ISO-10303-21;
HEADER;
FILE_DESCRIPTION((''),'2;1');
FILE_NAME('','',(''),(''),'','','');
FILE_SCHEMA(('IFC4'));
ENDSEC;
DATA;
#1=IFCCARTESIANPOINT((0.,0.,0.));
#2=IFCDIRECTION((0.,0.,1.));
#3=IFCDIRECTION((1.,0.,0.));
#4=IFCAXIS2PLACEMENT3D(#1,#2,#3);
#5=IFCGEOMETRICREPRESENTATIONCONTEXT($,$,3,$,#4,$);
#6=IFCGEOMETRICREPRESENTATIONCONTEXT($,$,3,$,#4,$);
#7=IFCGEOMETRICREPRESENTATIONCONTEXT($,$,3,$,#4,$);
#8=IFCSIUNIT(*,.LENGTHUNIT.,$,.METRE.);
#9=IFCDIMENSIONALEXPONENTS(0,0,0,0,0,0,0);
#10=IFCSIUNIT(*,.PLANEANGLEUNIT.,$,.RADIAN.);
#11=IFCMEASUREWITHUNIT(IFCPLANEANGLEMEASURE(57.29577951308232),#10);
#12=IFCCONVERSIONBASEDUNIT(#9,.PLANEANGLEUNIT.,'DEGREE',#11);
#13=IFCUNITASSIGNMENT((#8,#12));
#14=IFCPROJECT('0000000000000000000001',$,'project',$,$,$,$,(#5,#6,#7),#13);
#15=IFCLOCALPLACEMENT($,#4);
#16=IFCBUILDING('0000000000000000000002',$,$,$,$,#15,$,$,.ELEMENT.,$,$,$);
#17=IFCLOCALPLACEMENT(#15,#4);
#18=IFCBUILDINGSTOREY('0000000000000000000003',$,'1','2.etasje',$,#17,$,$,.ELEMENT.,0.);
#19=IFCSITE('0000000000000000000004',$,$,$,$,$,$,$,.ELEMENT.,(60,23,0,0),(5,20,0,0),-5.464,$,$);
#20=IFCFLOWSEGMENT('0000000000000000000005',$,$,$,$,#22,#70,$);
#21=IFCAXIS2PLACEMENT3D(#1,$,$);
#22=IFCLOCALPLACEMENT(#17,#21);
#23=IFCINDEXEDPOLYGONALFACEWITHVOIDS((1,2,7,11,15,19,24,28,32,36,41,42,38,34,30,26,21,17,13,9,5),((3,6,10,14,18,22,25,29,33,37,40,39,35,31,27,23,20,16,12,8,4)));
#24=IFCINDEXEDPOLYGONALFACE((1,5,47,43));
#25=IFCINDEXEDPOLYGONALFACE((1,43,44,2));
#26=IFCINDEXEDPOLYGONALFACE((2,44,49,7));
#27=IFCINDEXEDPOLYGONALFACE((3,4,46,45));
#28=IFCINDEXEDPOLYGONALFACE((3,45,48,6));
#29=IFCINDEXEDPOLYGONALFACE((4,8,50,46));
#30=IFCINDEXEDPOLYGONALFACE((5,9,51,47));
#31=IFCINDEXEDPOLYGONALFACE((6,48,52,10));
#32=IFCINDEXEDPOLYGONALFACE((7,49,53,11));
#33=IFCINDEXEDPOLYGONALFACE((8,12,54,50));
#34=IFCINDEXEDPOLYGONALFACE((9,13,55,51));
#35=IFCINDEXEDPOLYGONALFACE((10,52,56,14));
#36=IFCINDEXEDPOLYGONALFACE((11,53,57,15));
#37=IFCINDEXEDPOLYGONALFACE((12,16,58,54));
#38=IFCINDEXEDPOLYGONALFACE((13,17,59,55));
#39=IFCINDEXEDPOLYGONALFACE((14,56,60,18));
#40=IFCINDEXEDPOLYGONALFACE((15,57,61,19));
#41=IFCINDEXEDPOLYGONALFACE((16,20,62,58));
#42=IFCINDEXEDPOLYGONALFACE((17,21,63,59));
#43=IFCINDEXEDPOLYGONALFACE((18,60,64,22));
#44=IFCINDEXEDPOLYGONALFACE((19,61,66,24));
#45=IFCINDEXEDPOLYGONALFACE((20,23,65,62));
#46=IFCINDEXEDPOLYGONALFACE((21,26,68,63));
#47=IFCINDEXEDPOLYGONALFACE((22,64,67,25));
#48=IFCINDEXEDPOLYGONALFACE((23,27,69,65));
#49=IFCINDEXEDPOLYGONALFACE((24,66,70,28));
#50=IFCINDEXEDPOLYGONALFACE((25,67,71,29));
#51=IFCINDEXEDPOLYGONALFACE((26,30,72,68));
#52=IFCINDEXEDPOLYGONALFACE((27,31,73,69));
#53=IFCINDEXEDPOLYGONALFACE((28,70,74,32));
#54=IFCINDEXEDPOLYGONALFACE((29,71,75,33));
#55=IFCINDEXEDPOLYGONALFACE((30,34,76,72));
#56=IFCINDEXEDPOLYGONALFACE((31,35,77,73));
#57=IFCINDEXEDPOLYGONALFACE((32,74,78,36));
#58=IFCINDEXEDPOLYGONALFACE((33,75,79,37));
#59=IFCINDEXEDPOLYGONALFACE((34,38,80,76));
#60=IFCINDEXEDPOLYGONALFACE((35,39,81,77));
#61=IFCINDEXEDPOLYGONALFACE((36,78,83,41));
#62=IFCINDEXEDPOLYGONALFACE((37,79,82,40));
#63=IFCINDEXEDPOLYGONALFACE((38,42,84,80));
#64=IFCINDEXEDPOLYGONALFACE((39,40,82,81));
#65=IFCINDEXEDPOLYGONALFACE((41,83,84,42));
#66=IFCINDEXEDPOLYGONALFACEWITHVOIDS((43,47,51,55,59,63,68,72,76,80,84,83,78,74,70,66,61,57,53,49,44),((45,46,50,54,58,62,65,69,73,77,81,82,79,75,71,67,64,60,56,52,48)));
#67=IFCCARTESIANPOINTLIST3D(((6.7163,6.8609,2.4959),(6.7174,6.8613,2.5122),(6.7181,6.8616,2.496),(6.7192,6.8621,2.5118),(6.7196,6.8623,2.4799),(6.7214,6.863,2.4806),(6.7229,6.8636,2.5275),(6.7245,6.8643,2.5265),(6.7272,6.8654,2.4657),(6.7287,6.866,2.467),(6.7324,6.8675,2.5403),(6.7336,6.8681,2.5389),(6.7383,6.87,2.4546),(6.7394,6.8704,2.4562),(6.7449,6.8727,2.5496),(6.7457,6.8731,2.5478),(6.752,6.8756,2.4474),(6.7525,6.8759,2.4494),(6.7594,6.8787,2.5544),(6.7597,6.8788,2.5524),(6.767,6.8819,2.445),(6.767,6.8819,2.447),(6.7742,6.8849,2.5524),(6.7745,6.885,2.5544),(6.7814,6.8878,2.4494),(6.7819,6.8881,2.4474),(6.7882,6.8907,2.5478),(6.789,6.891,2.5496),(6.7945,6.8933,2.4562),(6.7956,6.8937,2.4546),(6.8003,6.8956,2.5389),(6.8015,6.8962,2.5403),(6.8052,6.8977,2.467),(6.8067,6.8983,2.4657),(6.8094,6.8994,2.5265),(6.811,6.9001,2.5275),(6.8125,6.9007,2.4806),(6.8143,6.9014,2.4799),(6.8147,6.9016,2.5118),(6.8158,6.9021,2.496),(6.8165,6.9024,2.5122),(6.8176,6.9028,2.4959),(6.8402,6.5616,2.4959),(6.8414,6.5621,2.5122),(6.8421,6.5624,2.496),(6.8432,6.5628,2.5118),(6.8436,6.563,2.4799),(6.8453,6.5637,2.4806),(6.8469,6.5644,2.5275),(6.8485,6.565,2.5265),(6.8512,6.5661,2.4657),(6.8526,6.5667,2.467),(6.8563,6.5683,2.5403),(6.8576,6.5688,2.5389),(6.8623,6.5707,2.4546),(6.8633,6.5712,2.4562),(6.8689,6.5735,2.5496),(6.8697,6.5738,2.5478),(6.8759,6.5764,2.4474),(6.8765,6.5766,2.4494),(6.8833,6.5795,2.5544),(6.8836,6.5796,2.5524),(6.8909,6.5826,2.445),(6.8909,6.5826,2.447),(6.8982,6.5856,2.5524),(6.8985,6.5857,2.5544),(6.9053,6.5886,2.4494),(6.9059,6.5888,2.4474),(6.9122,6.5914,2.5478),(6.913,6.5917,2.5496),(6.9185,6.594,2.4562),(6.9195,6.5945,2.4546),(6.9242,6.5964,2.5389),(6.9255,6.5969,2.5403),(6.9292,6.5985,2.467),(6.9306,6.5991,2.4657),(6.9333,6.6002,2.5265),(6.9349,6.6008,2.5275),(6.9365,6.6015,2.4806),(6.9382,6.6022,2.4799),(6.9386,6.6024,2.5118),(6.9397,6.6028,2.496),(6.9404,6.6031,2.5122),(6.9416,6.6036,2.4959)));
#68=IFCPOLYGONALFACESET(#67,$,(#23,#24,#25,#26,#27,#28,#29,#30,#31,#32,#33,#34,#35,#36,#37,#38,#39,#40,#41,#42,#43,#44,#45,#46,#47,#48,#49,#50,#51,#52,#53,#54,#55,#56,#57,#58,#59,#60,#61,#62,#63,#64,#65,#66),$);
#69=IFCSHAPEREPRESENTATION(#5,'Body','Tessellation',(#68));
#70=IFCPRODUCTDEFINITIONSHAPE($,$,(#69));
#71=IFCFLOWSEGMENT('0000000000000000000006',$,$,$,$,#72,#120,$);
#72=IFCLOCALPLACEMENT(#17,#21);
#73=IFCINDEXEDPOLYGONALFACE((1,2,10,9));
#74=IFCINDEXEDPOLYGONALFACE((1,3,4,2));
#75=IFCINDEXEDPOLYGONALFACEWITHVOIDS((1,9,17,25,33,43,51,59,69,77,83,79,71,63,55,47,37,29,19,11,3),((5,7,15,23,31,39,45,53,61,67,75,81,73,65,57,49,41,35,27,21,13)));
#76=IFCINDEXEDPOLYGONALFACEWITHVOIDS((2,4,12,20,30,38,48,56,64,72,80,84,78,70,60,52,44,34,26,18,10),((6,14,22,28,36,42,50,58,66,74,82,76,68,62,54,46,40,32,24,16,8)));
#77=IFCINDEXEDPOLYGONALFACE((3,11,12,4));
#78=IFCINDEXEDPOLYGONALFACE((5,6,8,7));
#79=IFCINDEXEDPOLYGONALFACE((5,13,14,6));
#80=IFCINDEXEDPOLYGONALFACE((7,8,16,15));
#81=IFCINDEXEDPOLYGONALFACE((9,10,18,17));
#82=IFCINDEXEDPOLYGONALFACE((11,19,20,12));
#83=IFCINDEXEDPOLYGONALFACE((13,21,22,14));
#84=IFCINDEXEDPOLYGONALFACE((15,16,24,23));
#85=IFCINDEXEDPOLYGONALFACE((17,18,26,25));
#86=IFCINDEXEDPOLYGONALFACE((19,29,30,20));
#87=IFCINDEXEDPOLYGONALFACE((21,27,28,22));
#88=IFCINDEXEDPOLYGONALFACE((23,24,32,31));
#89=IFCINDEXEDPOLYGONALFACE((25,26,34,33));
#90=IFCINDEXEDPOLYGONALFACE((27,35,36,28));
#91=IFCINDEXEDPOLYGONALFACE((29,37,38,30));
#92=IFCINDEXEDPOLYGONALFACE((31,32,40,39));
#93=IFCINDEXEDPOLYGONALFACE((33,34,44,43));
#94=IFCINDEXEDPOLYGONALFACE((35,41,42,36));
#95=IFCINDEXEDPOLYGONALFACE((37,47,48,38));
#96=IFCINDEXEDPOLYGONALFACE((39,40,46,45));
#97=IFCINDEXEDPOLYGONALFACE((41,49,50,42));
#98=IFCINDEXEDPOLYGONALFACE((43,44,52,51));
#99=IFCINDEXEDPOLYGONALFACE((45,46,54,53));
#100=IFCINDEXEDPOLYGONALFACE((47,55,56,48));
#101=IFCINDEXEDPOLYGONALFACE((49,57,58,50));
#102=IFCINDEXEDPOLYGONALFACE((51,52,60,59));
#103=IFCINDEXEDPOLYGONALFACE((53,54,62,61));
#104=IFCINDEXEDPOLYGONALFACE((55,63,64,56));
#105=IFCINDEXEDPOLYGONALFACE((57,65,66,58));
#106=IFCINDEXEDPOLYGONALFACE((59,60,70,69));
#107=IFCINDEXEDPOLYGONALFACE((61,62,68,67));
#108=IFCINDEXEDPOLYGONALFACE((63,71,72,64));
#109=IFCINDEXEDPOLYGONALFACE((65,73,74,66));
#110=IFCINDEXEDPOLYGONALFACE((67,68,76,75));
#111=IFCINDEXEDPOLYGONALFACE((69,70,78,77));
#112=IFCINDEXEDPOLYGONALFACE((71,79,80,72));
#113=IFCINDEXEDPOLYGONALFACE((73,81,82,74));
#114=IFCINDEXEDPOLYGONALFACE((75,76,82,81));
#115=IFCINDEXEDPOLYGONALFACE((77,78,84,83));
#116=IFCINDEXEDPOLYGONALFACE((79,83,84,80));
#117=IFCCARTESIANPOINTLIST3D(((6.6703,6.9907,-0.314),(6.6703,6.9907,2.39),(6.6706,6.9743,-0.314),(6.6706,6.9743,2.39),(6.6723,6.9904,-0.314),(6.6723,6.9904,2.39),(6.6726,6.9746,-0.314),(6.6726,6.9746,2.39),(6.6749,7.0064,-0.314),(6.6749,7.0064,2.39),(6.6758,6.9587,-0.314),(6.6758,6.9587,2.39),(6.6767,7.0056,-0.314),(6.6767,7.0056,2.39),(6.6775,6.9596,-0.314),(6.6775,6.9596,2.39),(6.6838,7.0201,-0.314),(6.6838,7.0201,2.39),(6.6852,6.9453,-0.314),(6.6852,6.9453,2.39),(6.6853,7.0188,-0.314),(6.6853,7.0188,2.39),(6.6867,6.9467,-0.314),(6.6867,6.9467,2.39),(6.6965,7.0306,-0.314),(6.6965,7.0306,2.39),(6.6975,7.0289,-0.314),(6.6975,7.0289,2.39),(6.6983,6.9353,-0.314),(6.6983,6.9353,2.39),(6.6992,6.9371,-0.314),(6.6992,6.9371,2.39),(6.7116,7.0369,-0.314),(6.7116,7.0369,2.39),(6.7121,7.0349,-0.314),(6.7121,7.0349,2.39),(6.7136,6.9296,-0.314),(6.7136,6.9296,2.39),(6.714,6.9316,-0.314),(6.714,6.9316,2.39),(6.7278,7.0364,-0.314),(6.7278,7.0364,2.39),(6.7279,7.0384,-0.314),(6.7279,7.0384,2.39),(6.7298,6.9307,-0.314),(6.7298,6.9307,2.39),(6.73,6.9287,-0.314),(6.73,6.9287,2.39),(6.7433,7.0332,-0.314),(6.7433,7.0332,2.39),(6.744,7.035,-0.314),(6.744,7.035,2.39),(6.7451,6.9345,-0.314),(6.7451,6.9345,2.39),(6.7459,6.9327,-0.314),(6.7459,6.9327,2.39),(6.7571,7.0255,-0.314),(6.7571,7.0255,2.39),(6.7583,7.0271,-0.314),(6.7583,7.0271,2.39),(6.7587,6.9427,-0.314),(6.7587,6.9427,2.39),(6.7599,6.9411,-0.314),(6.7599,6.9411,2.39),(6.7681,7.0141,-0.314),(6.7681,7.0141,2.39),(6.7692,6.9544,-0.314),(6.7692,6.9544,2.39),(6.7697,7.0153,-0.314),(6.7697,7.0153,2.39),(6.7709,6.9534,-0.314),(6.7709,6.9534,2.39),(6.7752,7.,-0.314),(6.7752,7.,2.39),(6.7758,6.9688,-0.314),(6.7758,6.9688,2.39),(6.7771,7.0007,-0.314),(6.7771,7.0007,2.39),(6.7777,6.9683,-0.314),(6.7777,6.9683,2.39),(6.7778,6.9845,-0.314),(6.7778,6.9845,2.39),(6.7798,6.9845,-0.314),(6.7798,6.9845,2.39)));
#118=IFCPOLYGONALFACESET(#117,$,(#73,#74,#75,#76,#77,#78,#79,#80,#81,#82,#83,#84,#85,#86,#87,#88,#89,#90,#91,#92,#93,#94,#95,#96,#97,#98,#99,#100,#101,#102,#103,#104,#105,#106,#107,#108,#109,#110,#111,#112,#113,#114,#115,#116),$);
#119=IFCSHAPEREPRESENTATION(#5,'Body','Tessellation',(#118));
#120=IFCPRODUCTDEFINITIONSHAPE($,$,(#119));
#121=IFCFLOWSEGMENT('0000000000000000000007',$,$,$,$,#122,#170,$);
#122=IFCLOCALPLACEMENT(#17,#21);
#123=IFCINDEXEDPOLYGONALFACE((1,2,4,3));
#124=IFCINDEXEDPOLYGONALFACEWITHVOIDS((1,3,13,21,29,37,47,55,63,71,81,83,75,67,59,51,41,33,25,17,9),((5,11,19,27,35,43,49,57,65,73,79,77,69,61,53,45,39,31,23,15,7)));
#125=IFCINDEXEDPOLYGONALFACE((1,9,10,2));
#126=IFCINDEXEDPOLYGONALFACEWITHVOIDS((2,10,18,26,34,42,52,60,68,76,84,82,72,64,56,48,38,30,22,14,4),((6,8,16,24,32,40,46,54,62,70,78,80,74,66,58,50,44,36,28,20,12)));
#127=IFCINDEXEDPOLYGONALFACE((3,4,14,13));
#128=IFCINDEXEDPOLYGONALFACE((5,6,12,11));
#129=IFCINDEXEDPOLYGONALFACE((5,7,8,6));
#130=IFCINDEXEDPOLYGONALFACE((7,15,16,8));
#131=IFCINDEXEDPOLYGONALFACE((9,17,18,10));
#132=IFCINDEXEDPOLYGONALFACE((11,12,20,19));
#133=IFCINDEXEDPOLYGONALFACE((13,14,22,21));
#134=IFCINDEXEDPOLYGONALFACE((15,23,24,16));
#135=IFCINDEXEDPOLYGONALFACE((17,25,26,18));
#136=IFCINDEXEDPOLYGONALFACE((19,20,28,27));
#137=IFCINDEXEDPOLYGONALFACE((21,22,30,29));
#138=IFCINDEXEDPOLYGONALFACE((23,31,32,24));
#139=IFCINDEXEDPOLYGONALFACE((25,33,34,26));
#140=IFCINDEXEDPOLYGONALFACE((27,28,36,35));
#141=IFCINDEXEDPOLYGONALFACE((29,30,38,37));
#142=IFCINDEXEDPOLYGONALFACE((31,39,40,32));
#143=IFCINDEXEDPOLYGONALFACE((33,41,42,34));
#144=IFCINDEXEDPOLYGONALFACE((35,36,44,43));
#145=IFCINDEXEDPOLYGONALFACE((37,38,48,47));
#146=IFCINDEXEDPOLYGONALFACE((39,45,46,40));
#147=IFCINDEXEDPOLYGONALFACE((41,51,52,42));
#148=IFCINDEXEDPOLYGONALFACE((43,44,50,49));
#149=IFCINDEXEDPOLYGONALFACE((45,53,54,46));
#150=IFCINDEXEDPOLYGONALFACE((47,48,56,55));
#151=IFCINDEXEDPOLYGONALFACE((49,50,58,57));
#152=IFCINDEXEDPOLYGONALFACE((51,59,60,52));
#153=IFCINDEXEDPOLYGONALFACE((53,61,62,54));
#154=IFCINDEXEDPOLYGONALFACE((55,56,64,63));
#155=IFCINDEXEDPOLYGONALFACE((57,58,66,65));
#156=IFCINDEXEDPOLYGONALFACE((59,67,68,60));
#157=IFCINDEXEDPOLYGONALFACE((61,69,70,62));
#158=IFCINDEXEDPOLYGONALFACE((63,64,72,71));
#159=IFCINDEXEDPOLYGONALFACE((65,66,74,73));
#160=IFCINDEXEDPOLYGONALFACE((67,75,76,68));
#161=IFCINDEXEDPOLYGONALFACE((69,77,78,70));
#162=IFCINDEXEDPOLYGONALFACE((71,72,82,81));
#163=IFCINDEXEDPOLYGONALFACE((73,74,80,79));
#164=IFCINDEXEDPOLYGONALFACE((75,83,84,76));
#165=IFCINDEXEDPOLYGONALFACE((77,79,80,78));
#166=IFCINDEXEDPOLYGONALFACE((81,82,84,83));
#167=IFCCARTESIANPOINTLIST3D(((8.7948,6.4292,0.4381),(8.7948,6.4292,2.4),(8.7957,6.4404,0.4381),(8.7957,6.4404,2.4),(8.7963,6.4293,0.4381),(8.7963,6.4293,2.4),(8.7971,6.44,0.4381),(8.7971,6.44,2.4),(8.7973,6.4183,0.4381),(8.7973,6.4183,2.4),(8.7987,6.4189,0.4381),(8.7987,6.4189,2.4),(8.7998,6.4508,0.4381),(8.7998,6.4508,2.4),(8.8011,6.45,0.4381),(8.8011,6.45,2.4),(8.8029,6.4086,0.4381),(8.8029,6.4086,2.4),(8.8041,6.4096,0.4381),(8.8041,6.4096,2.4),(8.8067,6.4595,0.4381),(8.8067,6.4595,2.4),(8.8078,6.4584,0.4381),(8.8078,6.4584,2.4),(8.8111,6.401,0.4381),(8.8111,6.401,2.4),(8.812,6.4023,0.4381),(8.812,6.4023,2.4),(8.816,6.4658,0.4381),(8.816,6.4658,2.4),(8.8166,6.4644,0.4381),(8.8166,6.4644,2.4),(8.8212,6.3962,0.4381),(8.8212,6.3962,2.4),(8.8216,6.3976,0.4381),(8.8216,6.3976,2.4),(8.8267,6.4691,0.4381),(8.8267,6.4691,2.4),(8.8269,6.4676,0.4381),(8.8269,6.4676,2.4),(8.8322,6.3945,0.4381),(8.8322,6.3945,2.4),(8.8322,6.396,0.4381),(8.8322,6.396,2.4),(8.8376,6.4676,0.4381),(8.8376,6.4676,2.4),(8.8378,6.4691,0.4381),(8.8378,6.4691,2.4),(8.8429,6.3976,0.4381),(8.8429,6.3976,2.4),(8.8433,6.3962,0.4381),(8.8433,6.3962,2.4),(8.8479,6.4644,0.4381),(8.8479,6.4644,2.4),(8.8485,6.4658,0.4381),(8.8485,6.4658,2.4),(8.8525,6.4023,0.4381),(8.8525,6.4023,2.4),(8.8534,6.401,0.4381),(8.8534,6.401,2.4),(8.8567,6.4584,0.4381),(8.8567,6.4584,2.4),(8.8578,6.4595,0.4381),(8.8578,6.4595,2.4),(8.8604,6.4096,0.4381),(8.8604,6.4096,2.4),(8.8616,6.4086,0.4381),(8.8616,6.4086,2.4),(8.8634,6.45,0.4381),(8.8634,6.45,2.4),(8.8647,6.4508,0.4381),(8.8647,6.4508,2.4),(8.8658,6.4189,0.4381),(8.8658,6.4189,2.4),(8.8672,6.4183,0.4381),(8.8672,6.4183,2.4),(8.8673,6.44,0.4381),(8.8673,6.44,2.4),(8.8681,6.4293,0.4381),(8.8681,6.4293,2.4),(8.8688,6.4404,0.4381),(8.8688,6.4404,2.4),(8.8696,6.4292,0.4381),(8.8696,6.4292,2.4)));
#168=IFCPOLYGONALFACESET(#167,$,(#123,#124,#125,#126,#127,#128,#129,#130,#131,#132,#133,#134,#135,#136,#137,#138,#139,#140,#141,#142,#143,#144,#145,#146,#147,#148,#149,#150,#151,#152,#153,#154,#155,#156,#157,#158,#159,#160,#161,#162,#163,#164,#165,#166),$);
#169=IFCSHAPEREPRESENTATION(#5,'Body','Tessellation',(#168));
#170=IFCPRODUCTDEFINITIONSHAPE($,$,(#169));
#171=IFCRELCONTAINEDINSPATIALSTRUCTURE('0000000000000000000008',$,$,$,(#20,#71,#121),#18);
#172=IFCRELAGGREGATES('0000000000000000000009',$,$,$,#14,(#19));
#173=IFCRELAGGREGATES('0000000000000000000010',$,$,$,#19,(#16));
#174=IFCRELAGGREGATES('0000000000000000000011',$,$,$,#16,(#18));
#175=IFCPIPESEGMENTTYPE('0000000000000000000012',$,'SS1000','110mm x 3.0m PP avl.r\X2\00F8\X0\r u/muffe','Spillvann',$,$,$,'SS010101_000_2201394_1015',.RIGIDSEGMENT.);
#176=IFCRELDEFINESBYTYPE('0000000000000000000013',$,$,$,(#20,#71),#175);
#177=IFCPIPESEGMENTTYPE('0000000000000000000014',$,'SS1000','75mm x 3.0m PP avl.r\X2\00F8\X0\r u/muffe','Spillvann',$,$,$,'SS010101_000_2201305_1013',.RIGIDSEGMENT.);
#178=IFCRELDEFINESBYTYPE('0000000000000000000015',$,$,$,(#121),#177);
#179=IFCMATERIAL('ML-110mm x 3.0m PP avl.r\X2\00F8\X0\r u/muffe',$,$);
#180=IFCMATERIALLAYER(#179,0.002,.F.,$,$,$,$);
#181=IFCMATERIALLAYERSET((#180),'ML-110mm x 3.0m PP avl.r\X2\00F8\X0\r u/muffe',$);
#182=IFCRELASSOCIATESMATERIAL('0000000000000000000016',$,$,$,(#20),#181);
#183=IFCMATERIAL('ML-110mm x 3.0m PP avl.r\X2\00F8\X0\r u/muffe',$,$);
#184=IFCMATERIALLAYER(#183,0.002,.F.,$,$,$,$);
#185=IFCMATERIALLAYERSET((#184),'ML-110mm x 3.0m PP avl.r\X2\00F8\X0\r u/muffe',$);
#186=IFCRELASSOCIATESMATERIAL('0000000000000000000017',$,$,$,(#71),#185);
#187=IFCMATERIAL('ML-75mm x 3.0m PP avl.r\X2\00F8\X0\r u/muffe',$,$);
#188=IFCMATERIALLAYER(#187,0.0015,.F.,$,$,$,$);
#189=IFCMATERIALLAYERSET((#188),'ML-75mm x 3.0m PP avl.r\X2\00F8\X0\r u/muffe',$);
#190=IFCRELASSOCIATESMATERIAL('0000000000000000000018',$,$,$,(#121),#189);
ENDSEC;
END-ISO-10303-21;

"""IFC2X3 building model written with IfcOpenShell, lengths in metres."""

from ifc_helpers import new_model, entity, si_unit, converted_unit, frame, origin_with_axes, origin_2d_with_axis, place, context, project, spatial, hollow_circle, extrude, material, layer, layer_set, layer_usage, type_object, element, save


model = new_model("IFC2X3")

# Units and contexts
context_of_model_1 = context(None, 3, world=origin_with_axes())
context_of_model_2 = context(None, 3, world=origin_with_axes())
context_of_model_3 = context(None, 3, world=origin_with_axes())
ifc_project = project(units=[si_unit("LENGTHUNIT", "METRE"), converted_unit("PLANEANGLEUNIT", "DEGREE", entity("IfcPlaneAngleMeasure", 57.29577951308232), si_unit("PLANEANGLEUNIT", "RADIAN"), dimensions=[0, 0, 0, 0, 0, 0, 0])], contexts=[context_of_model_1, context_of_model_2, context_of_model_3])

# Site, building, storey
site = spatial("IfcSite", under=ifc_project, CompositionType="ELEMENT", RefLatitude=(60, 23, 0, 0), RefLongitude=(5, 20, 0, 0), RefElevation=-5.464)
building_placement = place(None, origin_with_axes())
building = spatial("IfcBuilding", under=site, at=building_placement, CompositionType="ELEMENT")
storey_placement = place(building_placement, origin_with_axes())
storey = spatial("IfcBuildingStorey", under=building, at=storey_placement, Name="1", Description="2.etasje", CompositionType="ELEMENT", Elevation=0.0)

# Flow segments
pipe_segment_type_1 = type_object("IfcPipeSegmentType", Name="SS1000", Description="110mm x 3.0m PP avl.rør u/muffe", ApplicableOccurrence="Spillvann", ElementType="SS010101_000_2201394_1015", PredefinedType="RIGIDSEGMENT")
ifc_material_1 = material(Name="ML-110mm x 3.0m PP avl.rør u/muffe")
ifc_layer_1 = layer(ifc_material_1, 0.002, ventilated=False)
ifc_layer_set_1 = layer_set([ifc_layer_1], Name="ML-110mm x 3.0m PP avl.rør u/muffe")
ifc_layer_usage_1 = layer_usage(ifc_layer_set_1, "AXIS2", "POSITIVE", 0.0)
flow_segment_1_placement = place(storey_placement, frame((6.8909, 6.5826, 2.5), z_axis=(-0.382683, 0.92388, 0.0), x_axis=(0.0, 0.0, -1.0)))
element("IfcFlowSegment", 1, at=flow_segment_1_placement, inside=storey, type_object=pipe_segment_type_1, material=ifc_layer_usage_1, context=context_of_model_1, shape_type="SweptSolid", body=[
    extrude(hollow_circle(Radius=0.055, WallThickness=0.002, at=origin_2d_with_axis()), origin_with_axes(), (0.0, 0.0, 1.0), 0.3239),
])
ifc_material_2 = material(Name="ML-110mm x 3.0m PP avl.rør u/muffe")
ifc_layer_2 = layer(ifc_material_2, 0.002, ventilated=False)
ifc_layer_set_2 = layer_set([ifc_layer_2], Name="ML-110mm x 3.0m PP avl.rør u/muffe")
ifc_layer_usage_2 = layer_usage(ifc_layer_set_2, "AXIS2", "POSITIVE", 0.0)
flow_segment_2_placement = place(storey_placement, frame((6.7249, 6.9835, 2.39), z_axis=(0.0, 0.0, -1.0), x_axis=(0.382683, -0.92388, 0.0)))
element("IfcFlowSegment", 2, at=flow_segment_2_placement, inside=storey, type_object=pipe_segment_type_1, material=ifc_layer_usage_2, context=context_of_model_1, shape_type="SweptSolid", body=[
    extrude(hollow_circle(Radius=0.055, WallThickness=0.002, at=origin_2d_with_axis()), origin_with_axes(), (0.0, 0.0, 1.0), 2.704),
])
ifc_material_3 = material(Name="ML-75mm x 3.0m PP avl.rør u/muffe")
ifc_layer_3 = layer(ifc_material_3, 0.0015, ventilated=False)
ifc_layer_set_3 = layer_set([ifc_layer_3], Name="ML-75mm x 3.0m PP avl.rør u/muffe")
ifc_layer_usage_3 = layer_usage(ifc_layer_set_3, "AXIS2", "POSITIVE", 0.0)
pipe_segment_type_2 = type_object("IfcPipeSegmentType", Name="SS1000", Description="75mm x 3.0m PP avl.rør u/muffe", ApplicableOccurrence="Spillvann", ElementType="SS010101_000_2201305_1013", PredefinedType="RIGIDSEGMENT")
flow_segment_3_placement = place(storey_placement, frame((8.8322, 6.432, 2.4), z_axis=(0.0, 0.0, -1.0), x_axis=(0.0, -1.0, 0.0)))
element("IfcFlowSegment", 3, at=flow_segment_3_placement, inside=storey, type_object=pipe_segment_type_2, material=ifc_layer_usage_3, context=context_of_model_1, shape_type="SweptSolid", body=[
    extrude(hollow_circle(Radius=0.0375, WallThickness=0.0015, at=origin_2d_with_axis()), origin_with_axes(), (0.0, 0.0, 1.0), 1.9619),
])

save(model, "model.ifc")
